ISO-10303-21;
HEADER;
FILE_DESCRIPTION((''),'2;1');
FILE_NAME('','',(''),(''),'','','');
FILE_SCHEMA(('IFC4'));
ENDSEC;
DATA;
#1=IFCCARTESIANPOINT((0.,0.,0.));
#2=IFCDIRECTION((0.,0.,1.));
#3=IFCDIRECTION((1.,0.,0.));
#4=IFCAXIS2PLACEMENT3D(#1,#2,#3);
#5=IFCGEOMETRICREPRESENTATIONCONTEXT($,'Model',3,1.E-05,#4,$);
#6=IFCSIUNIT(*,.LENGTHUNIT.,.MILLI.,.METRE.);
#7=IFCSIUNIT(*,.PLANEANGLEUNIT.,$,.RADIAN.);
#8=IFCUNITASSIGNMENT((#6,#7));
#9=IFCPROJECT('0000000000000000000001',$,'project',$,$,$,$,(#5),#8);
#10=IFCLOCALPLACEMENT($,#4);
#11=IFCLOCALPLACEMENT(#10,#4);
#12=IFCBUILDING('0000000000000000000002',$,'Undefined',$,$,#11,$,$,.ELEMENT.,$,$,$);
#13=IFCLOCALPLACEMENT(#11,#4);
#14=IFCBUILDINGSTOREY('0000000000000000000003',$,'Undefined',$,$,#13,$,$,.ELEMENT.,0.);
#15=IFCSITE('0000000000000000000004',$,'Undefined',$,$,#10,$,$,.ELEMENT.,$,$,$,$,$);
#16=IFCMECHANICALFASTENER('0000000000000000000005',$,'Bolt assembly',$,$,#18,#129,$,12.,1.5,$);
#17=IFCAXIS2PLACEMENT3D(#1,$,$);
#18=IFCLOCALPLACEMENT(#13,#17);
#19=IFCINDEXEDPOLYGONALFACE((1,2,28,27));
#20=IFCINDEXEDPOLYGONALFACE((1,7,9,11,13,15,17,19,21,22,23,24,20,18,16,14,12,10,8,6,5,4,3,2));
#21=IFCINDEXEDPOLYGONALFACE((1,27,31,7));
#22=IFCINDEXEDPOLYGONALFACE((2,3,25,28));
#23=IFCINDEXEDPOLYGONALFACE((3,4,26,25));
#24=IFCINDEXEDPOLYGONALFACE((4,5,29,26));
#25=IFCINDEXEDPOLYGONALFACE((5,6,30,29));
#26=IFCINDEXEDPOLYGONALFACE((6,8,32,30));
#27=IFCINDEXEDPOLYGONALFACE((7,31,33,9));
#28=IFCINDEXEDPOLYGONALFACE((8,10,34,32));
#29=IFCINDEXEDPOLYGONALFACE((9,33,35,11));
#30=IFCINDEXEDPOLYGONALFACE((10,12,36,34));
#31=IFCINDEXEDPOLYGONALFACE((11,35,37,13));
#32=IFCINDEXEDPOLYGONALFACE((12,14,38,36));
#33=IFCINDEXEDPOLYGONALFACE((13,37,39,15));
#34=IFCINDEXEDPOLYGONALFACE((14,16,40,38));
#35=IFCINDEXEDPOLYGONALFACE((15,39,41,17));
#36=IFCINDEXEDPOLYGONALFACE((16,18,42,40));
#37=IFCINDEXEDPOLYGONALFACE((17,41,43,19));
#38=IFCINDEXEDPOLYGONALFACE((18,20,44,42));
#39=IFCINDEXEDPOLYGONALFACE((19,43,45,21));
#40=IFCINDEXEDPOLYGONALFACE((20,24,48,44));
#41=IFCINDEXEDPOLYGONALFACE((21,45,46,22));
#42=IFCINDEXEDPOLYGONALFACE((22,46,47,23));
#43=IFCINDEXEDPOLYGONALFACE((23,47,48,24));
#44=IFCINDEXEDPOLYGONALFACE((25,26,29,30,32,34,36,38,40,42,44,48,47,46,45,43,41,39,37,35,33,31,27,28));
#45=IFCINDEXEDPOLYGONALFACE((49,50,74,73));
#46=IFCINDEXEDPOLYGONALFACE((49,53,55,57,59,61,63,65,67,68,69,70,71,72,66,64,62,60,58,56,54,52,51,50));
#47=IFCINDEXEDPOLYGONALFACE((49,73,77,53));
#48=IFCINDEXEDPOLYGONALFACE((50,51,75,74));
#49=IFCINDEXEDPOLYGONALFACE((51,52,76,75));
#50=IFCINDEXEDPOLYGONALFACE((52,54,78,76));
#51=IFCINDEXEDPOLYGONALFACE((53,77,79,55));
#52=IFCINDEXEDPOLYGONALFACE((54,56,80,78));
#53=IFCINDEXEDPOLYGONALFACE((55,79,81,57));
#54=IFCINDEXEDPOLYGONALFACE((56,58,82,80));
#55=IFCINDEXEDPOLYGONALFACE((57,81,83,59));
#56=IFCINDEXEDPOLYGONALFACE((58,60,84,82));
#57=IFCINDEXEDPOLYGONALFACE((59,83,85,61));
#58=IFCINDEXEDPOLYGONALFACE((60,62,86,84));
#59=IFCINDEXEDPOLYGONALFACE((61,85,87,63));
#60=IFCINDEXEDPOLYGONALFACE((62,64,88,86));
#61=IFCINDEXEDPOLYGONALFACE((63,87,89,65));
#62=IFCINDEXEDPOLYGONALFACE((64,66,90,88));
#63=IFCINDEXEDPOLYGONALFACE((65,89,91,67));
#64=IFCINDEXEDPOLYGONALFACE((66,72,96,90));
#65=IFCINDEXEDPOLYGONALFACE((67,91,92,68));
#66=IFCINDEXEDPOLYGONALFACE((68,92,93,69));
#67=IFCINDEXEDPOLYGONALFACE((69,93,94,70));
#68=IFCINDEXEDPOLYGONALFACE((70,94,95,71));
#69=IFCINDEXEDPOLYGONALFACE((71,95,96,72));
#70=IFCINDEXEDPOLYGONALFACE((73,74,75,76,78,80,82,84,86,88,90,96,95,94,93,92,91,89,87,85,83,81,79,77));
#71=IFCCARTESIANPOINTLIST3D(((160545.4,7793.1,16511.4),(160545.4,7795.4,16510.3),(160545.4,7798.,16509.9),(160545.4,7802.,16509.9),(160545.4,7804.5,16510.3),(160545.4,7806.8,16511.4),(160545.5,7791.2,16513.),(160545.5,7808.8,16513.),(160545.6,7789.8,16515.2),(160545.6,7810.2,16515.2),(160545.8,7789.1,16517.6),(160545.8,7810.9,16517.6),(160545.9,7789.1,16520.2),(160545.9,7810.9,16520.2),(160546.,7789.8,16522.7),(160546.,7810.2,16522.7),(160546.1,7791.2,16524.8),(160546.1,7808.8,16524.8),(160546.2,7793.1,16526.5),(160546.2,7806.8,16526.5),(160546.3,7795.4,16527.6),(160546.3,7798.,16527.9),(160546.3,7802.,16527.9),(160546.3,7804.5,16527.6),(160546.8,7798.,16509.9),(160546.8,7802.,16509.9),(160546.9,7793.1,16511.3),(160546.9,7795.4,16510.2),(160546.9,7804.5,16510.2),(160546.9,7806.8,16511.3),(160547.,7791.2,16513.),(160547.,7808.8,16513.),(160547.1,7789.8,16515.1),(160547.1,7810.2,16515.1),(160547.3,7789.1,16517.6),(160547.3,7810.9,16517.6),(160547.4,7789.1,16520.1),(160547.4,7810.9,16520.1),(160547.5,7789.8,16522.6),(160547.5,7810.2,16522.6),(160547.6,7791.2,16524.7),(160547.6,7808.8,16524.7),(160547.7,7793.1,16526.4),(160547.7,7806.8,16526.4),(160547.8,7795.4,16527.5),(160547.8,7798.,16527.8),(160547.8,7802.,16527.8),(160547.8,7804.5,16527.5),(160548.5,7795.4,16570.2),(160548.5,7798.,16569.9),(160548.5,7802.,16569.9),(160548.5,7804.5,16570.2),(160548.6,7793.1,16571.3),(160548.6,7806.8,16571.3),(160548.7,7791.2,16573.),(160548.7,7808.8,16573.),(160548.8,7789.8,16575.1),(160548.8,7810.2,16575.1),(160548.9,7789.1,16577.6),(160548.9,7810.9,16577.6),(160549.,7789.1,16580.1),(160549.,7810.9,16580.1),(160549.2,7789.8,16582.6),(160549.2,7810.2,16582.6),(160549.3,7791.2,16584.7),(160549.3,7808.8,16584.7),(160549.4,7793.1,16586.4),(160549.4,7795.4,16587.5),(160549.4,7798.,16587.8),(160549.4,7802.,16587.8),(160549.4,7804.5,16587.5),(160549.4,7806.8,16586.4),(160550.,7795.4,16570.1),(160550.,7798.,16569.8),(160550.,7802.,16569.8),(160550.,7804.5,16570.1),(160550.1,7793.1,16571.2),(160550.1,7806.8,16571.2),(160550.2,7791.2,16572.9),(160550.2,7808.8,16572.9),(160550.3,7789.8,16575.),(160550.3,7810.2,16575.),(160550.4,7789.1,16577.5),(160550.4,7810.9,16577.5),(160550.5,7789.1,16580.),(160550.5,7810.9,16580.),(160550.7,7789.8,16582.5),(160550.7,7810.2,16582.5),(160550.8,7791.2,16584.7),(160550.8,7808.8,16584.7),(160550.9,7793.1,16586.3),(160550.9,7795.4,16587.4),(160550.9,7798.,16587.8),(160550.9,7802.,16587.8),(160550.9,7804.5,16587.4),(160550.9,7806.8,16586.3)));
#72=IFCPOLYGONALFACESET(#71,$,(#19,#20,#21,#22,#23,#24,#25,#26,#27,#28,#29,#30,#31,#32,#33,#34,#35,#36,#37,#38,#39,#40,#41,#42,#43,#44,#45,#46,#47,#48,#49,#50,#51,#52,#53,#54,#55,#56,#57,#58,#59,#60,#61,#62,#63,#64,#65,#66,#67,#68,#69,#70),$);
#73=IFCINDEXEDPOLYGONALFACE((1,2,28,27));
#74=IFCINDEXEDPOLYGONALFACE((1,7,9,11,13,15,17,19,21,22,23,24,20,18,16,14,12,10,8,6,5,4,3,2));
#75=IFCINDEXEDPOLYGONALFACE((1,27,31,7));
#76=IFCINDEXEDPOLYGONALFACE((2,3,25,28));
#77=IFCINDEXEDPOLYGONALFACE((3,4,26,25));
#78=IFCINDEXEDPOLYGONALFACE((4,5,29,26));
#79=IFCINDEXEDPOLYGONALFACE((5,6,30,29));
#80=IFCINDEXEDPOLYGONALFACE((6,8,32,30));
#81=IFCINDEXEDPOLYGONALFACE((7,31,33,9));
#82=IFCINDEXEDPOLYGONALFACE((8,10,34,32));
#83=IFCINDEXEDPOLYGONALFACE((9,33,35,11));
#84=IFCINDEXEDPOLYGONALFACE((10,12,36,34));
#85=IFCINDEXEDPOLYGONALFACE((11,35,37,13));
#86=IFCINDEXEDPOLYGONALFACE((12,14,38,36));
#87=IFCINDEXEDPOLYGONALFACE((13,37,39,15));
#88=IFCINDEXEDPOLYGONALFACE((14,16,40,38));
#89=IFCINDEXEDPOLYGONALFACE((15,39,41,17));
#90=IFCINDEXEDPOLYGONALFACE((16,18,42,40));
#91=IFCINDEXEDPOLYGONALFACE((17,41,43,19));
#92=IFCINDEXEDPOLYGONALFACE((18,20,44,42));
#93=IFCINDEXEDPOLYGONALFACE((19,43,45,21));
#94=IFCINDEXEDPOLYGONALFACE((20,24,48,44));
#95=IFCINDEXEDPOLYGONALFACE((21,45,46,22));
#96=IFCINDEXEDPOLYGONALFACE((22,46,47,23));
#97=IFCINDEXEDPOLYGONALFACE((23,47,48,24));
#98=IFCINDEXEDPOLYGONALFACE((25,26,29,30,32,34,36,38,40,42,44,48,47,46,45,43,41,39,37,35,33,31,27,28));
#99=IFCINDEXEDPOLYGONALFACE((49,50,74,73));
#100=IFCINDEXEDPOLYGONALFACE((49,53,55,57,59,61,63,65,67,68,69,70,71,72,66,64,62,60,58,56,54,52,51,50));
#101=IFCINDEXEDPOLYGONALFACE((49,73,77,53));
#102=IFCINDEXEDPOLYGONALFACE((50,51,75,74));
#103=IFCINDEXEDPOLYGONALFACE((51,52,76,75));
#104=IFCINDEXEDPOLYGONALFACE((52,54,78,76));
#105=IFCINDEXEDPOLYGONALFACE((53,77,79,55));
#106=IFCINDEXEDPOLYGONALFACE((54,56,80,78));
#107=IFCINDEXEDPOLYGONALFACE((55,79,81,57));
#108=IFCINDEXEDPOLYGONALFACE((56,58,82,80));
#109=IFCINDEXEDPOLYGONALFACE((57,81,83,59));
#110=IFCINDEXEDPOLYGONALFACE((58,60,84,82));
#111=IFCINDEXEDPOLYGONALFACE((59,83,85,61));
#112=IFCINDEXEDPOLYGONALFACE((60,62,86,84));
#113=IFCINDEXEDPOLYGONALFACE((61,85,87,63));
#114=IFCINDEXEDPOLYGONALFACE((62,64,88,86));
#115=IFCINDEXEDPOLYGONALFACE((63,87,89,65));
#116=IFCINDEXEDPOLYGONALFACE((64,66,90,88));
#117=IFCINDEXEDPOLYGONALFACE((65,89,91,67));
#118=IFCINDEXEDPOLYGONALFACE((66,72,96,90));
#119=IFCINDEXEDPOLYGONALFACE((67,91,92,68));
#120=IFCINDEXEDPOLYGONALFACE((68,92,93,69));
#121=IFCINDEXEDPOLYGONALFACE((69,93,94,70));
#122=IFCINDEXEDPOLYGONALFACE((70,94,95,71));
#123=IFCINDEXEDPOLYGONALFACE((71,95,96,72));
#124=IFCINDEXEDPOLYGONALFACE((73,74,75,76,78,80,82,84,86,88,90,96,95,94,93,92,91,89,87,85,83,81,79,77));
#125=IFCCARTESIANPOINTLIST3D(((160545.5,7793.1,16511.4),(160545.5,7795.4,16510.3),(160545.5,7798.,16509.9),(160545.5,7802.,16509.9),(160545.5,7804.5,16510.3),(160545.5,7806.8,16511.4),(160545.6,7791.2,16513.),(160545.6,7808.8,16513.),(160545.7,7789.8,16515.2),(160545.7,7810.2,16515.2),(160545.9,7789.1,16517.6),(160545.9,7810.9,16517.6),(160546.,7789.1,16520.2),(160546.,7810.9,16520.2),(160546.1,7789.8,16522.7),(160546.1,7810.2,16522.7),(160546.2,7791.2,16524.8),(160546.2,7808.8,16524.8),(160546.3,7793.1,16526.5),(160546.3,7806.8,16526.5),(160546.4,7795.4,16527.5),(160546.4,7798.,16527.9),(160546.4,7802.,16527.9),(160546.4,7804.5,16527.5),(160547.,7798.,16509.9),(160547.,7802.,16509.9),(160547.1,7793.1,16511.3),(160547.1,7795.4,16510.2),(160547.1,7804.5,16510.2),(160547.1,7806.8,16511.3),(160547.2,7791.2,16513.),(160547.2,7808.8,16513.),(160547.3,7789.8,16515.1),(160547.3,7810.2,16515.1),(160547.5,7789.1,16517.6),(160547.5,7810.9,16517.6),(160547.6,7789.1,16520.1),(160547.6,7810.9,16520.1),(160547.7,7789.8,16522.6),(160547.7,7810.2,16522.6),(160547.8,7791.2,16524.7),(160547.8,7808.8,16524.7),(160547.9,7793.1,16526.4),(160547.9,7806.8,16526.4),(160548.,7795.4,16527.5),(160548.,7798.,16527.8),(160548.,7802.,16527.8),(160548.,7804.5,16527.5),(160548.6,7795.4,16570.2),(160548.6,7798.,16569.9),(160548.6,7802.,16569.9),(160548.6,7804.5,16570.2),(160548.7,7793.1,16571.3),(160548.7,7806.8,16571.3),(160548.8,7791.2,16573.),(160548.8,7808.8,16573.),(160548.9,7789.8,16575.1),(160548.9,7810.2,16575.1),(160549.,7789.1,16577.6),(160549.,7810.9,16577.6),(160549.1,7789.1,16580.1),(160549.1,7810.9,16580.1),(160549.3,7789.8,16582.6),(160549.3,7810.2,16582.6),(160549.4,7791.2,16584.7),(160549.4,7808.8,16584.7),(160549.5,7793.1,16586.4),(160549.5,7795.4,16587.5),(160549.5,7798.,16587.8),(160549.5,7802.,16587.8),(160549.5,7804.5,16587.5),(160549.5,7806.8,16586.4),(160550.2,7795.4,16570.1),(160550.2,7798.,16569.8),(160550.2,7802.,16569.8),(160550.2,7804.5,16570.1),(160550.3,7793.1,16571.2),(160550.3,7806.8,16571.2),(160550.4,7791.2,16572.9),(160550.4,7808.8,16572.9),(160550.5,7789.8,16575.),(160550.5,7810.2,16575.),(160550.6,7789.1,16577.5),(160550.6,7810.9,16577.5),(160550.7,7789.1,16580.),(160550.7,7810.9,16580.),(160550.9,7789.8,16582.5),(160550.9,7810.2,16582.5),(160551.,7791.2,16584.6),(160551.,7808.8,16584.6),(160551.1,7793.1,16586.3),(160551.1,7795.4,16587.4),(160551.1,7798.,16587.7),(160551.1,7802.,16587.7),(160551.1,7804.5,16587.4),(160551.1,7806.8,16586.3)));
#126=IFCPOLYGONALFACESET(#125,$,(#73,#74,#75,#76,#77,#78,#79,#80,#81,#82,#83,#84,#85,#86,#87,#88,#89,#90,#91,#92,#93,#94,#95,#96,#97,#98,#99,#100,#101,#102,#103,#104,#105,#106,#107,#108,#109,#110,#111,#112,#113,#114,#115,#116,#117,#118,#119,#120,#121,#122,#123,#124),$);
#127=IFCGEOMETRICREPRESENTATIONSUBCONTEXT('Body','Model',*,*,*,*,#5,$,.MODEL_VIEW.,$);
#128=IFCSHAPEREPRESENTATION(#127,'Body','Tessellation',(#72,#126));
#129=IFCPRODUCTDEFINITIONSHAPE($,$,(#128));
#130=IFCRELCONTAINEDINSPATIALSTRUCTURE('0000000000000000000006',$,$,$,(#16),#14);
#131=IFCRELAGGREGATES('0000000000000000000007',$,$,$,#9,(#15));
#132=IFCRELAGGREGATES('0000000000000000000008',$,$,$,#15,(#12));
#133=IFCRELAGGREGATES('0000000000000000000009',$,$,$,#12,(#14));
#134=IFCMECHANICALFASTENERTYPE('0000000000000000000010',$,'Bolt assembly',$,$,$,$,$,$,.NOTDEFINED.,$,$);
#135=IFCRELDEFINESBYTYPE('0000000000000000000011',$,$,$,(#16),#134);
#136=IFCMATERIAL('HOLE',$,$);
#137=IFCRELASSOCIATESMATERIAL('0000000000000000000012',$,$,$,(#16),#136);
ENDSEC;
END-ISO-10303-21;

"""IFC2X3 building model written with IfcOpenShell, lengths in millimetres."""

from ifc_helpers import new_model, entity, si_unit, frame, origin_with_axes, place, context, subcontext, project, spatial, source, transform, mapped, material, type_object, element, save


model = new_model("IFC2X3")

# Units and contexts
model_context = context("Model", 3, precision=1e-05, world=origin_with_axes())
body_context = subcontext(model_context, "Body", "Model", "MODEL_VIEW")
ifc_project = project(units=[si_unit("LENGTHUNIT", "METRE", prefix="MILLI"), si_unit("PLANEANGLEUNIT", "RADIAN")], contexts=[model_context])

# Site, building, storey
site_placement = place(None, origin_with_axes())
site = spatial("IfcSite", under=ifc_project, at=site_placement, Name="Undefined", CompositionType="ELEMENT")
building_placement = place(site_placement, origin_with_axes())
building = spatial("IfcBuilding", under=site, at=building_placement, Name="Undefined", CompositionType="ELEMENT")
storey_placement = place(building_placement, origin_with_axes())
storey = spatial("IfcBuildingStorey", under=building, at=storey_placement, Name="Undefined", CompositionType="ELEMENT", Elevation=0.0)

# Mechanical fastener
ifc_material_1 = material(Name="HOLE")
mechanical_fastener_type = type_object("IfcMechanicalFastenerType", Name="Bolt assembly")
shared_circle_1 = entity("IfcCircle", entity("IfcAxis2Placement2D", entity("IfcCartesianPoint", [0.0, -2.0]), entity("IfcDirection", [1.0, 0.0])), 9.0)
shared_circle_2 = entity("IfcCircle", entity("IfcAxis2Placement2D", entity("IfcCartesianPoint", [0.0, 2.0]), entity("IfcDirection", [-1.0, 0.0])), 9.0)
shared_composite_curve = entity("IfcCompositeCurve", [entity("IfcCompositeCurveSegment", "CONTINUOUS", True, entity("IfcPolyline", [entity("IfcCartesianPoint", [9.0, 2.0]), entity("IfcCartesianPoint", [9.0, -2.0])])), entity("IfcCompositeCurveSegment", "CONTINUOUS", True, entity("IfcTrimmedCurve", shared_circle_1, [entity("IfcParameterValue", 0.0)], [entity("IfcParameterValue", 3.141593)], False, "PARAMETER")), entity("IfcCompositeCurveSegment", "CONTINUOUS", True, entity("IfcPolyline", [entity("IfcCartesianPoint", [-9.0, -2.0]), entity("IfcCartesianPoint", [-9.0, 2.0])])), entity("IfcCompositeCurveSegment", "DISCONTINUOUS", True, entity("IfcTrimmedCurve", shared_circle_2, [entity("IfcParameterValue", 0.0)], [entity("IfcParameterValue", 3.141593)], False, "PARAMETER"))], False)
shared_shape_1 = source(origin_with_axes(), body_context, "Body", "SweptSolid", [
    entity("IfcExtrudedAreaSolid", entity("IfcArbitraryClosedProfileDef", "AREA", None, shared_composite_curve), entity("IfcAxis2Placement3D", entity("IfcCartesianPoint", [0.0, 0.1, 0.0]), entity("IfcDirection", [0.0, 1.0, 0.0]), entity("IfcDirection", [1.0, 0.0, 0.0])), entity("IfcDirection", [0.0, 0.0, 1.0]), 1.5),
    entity("IfcExtrudedAreaSolid", entity("IfcArbitraryClosedProfileDef", "AREA", None, shared_composite_curve), entity("IfcAxis2Placement3D", entity("IfcCartesianPoint", [0.0, -0.1, 0.0]), entity("IfcDirection", [0.0, 1.0, 0.0]), entity("IfcDirection", [1.0, 0.0, 0.0])), entity("IfcDirection", [0.0, 0.0, 1.0]), 1.6),
])
mechanical_fastener_1_placement = place(storey_placement, frame((160550.6, 7800.0, 16578.8), z_axis=(0.0, 1.0, 0.0), x_axis=(-0.052392, 0.0, -0.998627)))
element("IfcMechanicalFastener", 1, at=mechanical_fastener_1_placement, inside=storey, type_object=mechanical_fastener_type, material=ifc_material_1, Name="Bolt assembly", NominalDiameter=12.0, NominalLength=1.5, context=body_context, shape_type="MappedRepresentation", body=[
    mapped(shared_shape_1, transform((0.0, 0.0, 0.0))),
    mapped(shared_shape_1, transform((60.0, 0.0, 0.0))),
])

save(model, "model.ifc")
